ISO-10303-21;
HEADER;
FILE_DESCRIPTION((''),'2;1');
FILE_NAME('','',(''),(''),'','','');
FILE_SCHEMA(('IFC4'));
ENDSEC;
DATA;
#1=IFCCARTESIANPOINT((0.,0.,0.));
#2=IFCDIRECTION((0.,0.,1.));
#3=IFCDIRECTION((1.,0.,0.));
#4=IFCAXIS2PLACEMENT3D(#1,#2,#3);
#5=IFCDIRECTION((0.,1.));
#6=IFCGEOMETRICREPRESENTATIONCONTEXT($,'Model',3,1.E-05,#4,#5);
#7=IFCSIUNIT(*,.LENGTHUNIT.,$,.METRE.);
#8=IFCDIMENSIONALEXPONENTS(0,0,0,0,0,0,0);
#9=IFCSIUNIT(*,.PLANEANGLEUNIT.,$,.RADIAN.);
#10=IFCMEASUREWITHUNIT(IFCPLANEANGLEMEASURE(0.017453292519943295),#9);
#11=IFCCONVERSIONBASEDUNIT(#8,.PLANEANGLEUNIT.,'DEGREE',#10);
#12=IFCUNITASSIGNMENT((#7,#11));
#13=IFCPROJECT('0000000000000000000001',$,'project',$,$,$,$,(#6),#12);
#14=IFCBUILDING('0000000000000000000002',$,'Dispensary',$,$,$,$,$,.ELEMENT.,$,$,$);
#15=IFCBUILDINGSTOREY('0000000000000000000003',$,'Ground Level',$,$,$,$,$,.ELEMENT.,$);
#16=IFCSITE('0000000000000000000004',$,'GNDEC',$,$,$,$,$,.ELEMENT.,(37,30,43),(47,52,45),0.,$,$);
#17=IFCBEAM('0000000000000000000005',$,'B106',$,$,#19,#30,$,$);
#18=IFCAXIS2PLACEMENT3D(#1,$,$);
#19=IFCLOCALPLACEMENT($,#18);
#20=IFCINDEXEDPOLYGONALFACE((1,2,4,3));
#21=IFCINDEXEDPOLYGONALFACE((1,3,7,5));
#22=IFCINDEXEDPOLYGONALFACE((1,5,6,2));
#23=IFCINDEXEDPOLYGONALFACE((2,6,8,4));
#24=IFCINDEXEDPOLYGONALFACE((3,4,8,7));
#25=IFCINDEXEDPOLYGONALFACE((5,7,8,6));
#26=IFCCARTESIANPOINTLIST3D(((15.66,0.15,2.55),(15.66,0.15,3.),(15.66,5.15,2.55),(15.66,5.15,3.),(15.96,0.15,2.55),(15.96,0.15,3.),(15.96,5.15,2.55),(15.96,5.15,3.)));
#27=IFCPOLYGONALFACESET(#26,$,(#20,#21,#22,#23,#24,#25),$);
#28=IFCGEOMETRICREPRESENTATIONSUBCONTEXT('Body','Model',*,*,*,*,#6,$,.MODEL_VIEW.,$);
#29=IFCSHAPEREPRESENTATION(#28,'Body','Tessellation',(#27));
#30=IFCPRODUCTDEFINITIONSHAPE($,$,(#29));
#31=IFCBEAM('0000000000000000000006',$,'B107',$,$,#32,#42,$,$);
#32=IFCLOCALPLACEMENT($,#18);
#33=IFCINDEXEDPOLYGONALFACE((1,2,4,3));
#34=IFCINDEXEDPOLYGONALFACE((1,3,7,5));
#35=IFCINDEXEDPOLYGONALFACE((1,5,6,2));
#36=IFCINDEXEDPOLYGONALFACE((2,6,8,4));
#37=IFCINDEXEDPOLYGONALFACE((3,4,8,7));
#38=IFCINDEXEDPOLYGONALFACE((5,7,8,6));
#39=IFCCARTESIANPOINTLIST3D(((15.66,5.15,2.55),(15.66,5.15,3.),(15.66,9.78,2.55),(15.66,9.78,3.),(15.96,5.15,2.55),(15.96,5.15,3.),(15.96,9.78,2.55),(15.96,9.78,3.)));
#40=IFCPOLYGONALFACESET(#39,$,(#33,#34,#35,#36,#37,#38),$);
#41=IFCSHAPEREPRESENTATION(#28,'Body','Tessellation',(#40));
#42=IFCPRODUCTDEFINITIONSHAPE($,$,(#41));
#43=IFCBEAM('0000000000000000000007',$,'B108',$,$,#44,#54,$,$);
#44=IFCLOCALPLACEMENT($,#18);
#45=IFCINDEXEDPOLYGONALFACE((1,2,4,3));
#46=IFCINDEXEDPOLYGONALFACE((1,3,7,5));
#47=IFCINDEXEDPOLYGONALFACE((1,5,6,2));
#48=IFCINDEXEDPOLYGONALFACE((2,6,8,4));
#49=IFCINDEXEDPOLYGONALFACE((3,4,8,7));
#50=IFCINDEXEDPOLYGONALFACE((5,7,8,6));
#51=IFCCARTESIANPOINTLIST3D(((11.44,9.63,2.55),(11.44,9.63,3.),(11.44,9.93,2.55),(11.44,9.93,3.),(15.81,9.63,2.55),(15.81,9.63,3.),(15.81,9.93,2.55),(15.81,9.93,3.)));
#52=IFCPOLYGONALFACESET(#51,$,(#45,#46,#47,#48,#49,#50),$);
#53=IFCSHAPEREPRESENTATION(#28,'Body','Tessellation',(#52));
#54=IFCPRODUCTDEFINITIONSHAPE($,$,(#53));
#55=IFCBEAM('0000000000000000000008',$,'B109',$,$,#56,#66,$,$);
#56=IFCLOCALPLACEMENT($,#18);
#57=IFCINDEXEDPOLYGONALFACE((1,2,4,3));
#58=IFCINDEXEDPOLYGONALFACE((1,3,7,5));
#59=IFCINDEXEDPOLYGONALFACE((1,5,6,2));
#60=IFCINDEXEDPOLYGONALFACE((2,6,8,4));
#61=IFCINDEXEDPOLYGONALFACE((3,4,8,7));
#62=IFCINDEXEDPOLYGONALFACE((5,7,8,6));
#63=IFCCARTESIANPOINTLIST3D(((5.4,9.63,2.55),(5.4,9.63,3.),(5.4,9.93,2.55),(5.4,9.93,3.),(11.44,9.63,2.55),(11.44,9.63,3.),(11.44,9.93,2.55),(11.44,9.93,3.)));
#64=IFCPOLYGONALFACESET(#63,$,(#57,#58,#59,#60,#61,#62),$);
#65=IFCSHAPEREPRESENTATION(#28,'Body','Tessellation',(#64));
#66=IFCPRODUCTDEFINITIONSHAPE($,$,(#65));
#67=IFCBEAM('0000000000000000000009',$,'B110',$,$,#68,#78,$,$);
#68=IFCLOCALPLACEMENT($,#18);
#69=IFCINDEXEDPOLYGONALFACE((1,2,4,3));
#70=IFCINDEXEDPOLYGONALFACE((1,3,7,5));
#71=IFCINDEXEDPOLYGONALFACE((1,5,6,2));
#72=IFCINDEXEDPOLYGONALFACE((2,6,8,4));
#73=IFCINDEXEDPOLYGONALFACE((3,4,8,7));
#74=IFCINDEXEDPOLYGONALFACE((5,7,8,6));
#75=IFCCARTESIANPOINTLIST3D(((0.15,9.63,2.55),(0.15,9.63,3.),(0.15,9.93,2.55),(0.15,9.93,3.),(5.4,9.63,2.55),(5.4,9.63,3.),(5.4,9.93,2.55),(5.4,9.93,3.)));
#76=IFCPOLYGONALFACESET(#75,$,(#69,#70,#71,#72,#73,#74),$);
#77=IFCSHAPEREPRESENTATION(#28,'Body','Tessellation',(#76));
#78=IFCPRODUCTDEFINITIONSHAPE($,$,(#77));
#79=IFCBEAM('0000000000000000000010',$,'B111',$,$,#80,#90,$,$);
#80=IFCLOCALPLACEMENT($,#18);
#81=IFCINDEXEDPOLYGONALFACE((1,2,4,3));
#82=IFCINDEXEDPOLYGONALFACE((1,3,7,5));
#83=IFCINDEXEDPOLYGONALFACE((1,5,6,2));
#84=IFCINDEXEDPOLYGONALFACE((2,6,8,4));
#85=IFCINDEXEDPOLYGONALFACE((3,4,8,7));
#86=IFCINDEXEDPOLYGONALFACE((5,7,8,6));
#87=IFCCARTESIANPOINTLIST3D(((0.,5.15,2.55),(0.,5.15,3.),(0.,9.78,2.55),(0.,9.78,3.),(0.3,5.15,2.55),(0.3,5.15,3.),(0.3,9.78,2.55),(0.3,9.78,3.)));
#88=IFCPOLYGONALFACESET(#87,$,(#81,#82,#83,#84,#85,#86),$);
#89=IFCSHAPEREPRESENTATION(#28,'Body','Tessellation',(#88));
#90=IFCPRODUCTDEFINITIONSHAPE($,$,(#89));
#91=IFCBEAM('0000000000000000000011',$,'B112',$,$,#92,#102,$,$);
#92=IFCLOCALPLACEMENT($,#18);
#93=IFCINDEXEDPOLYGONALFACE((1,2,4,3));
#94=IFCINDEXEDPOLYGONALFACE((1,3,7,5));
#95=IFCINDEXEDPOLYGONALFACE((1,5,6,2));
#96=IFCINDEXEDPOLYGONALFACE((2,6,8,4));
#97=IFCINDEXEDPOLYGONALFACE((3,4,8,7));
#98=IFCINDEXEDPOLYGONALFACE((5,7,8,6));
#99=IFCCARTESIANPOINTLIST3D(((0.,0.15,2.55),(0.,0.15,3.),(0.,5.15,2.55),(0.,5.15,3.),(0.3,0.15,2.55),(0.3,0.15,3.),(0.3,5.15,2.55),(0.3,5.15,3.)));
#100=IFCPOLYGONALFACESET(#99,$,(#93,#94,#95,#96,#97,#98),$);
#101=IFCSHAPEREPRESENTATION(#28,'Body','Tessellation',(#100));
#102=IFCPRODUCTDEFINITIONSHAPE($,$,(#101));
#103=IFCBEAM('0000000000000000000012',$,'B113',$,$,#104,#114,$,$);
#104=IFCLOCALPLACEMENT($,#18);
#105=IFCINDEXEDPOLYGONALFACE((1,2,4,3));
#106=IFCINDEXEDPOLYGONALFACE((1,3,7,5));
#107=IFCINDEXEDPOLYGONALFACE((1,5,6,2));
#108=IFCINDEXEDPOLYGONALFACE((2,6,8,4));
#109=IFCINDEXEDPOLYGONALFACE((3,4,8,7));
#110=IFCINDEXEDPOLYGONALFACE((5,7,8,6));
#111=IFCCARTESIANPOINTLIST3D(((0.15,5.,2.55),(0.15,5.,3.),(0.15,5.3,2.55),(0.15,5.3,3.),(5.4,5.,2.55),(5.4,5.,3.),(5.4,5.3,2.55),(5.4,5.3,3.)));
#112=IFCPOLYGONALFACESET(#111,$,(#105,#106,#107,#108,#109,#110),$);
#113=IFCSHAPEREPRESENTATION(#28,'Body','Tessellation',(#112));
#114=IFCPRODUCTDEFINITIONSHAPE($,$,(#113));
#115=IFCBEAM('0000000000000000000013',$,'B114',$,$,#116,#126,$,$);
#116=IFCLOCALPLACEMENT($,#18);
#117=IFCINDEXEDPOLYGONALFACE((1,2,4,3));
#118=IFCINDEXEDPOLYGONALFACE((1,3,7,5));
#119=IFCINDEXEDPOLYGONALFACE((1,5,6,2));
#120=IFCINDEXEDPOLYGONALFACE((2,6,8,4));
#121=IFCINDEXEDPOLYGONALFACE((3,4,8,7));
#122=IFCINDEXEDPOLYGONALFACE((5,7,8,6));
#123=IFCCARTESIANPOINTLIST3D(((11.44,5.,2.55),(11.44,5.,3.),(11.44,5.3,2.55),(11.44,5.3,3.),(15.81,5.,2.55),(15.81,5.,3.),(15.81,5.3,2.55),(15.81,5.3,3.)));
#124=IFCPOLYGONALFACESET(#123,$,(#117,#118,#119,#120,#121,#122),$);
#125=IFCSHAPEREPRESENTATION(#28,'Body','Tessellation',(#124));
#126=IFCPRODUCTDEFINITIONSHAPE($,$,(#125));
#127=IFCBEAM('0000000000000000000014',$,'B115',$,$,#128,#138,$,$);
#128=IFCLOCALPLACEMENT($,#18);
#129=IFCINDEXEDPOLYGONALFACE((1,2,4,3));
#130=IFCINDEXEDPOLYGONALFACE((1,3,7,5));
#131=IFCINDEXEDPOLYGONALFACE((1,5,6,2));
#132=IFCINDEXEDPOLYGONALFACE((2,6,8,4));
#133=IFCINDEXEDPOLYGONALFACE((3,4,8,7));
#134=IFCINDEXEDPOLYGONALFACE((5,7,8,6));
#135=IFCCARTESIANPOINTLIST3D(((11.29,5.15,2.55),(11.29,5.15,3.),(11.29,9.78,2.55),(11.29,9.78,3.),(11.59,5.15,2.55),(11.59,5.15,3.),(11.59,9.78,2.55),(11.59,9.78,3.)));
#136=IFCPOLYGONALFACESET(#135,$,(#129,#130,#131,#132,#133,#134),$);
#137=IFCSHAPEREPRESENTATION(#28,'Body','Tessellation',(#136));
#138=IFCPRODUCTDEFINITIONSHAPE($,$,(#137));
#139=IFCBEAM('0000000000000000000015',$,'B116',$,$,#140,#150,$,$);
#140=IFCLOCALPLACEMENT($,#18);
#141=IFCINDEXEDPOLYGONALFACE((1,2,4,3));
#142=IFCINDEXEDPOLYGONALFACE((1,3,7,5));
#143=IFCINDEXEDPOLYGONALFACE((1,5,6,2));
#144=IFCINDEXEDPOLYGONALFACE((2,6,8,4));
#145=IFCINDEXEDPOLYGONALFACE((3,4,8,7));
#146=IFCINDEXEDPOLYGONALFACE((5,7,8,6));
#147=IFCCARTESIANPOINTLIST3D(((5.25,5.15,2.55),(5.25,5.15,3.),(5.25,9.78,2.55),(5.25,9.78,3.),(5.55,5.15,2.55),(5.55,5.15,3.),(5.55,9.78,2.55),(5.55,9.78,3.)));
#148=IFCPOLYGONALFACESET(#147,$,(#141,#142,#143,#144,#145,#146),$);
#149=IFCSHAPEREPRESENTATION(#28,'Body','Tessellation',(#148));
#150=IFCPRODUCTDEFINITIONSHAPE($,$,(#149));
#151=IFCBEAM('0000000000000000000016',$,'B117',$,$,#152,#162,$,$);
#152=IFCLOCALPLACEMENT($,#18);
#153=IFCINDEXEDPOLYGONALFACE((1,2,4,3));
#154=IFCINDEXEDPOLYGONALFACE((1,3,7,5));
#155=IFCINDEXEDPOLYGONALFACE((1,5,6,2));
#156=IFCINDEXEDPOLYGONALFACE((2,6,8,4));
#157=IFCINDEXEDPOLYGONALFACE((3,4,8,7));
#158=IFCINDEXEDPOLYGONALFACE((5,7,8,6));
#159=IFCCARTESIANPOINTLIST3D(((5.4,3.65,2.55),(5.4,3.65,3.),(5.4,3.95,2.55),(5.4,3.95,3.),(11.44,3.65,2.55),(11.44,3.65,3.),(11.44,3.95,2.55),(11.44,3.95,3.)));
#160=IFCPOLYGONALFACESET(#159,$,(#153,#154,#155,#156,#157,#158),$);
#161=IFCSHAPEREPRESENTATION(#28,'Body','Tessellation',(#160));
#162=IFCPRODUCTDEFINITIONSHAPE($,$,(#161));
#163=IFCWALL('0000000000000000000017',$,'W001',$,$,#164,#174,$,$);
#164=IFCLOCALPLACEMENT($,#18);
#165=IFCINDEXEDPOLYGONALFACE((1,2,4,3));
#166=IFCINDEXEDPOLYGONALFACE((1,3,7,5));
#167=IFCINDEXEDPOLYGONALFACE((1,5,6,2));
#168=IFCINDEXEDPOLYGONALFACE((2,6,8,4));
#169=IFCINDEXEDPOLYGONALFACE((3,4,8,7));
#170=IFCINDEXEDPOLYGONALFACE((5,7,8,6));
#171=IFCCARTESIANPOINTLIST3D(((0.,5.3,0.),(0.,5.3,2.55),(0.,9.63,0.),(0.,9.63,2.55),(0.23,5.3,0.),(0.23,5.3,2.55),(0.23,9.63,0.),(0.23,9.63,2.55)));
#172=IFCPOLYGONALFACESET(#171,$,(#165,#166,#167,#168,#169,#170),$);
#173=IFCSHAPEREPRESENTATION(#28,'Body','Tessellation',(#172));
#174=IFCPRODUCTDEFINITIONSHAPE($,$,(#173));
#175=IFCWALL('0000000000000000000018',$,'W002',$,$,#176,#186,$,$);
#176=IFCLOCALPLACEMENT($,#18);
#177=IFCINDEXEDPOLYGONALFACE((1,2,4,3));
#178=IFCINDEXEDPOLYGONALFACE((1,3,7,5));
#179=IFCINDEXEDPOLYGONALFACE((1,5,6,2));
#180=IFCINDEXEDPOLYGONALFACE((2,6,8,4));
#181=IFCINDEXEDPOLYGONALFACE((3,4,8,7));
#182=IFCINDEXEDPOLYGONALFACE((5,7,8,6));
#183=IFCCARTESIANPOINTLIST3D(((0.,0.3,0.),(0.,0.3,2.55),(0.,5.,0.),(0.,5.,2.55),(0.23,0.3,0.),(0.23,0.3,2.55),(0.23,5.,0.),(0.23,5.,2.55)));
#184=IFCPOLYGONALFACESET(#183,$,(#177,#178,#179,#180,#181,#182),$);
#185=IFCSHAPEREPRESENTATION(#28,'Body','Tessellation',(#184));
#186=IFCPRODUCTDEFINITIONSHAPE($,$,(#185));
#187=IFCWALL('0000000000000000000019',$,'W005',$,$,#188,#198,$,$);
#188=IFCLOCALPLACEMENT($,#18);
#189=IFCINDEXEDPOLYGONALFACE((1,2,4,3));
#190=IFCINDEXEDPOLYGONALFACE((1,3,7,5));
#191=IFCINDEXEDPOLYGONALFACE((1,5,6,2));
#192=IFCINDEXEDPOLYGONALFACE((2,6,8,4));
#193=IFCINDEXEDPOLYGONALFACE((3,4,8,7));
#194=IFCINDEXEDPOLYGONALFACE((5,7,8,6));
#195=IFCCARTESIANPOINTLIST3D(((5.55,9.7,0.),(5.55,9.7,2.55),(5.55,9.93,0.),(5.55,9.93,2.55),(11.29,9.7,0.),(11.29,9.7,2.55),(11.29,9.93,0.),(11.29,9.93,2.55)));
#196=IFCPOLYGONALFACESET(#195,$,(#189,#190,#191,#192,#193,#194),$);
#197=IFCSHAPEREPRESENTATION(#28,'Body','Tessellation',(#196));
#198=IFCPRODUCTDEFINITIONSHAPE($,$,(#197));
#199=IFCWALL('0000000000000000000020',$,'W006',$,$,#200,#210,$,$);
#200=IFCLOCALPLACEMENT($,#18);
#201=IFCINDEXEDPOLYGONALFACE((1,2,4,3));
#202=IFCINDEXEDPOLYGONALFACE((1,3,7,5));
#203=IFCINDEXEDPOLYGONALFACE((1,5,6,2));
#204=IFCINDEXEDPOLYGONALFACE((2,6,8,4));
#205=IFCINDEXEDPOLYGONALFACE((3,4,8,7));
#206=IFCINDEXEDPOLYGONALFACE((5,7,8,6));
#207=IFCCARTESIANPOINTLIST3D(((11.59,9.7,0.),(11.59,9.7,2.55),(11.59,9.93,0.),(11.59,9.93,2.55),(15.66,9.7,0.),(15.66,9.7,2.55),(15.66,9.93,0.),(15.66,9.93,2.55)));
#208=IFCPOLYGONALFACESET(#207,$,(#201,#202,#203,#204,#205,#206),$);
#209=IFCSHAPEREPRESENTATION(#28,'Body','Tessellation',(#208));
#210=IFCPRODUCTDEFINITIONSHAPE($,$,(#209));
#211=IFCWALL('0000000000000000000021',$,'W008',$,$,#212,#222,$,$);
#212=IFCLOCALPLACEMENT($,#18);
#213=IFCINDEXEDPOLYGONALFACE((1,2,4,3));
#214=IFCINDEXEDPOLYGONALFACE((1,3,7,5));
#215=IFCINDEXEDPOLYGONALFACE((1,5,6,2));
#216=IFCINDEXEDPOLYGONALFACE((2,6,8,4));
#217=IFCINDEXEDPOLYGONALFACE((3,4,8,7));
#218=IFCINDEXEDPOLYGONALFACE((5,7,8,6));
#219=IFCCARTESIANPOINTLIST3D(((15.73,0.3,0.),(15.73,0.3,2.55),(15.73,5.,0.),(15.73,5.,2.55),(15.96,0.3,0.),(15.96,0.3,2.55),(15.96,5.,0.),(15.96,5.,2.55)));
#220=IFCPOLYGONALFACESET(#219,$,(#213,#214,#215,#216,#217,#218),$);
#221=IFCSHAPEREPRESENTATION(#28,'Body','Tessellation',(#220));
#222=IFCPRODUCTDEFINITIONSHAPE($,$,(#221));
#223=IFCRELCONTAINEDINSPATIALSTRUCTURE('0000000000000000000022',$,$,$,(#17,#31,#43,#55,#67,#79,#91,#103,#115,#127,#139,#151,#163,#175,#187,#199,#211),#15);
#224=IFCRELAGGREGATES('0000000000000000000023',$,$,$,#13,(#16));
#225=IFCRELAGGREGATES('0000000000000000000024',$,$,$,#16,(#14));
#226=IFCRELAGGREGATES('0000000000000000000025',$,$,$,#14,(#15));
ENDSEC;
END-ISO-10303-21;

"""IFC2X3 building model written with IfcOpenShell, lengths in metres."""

from ifc_helpers import new_model, entity, si_unit, converted_unit, direction, frame, frame_2d, origin_with_axes, place, context, subcontext, project, spatial, rectangle, extrude, element, save


model = new_model("IFC2X3")

# Units and contexts
model_context = context("Model", 3, precision=1e-05, world=origin_with_axes(), true_north=direction((0.0, 1.0)))
body_context = subcontext(model_context, "Body", "Model", "MODEL_VIEW")
ifc_project = project(units=[si_unit("LENGTHUNIT", "METRE"), converted_unit("PLANEANGLEUNIT", "DEGREE", entity("IfcPlaneAngleMeasure", 0.017453292519943295), si_unit("PLANEANGLEUNIT", "RADIAN"), dimensions=[0, 0, 0, 0, 0, 0, 0])], contexts=[model_context])

# Site, building, storey
site = spatial("IfcSite", under=ifc_project, Name="GNDEC", CompositionType="ELEMENT", RefLatitude=(37, 30, 43), RefLongitude=(47, 52, 45), RefElevation=0.0)
building = spatial("IfcBuilding", under=site, Name="Dispensary", CompositionType="ELEMENT")
storey = spatial("IfcBuildingStorey", under=building, Name="Ground Level", CompositionType="ELEMENT")

# Shared definitions
placement = place(None, origin_with_axes())

# Beams
element("IfcBeam", 1, at=placement, inside=storey, Name="B106", context=body_context, shape_type="SweptSolid", body=[
    extrude(rectangle(XDim=0.3, YDim=0.45, at=frame_2d((0.0, 0.0), x_axis=(0.0, 1.0))), frame((15.81, 0.15, 2.775), z_axis=(0.0, 1.0, 0.0), x_axis=(0.0, 0.0, -1.0)), (0.0, 0.0, 1.0), 5.0),
])
element("IfcBeam", 2, at=placement, inside=storey, Name="B107", context=body_context, shape_type="SweptSolid", body=[
    extrude(rectangle(XDim=0.3, YDim=0.45, at=frame_2d((0.0, 0.0), x_axis=(0.0, 1.0))), frame((15.81, 5.15, 2.775), z_axis=(0.0, 1.0, 0.0), x_axis=(0.0, 0.0, -1.0)), (0.0, 0.0, 1.0), 4.63),
])
element("IfcBeam", 3, at=placement, inside=storey, Name="B108", context=body_context, shape_type="SweptSolid", body=[
    extrude(rectangle(XDim=0.3, YDim=0.45, at=frame_2d((0.0, 0.0), x_axis=(0.0, 1.0))), frame((15.81, 9.78, 2.775), z_axis=(-1.0, 0.0, 0.0), x_axis=(0.0, 0.0, -1.0)), (0.0, 0.0, 1.0), 4.37),
])
element("IfcBeam", 4, at=placement, inside=storey, Name="B109", context=body_context, shape_type="SweptSolid", body=[
    extrude(rectangle(XDim=0.3, YDim=0.45, at=frame_2d((0.0, 0.0), x_axis=(0.0, 1.0))), frame((11.44, 9.78, 2.775), z_axis=(-1.0, 0.0, 0.0), x_axis=(0.0, 0.0, -1.0)), (0.0, 0.0, 1.0), 6.04),
])
element("IfcBeam", 5, at=placement, inside=storey, Name="B110", context=body_context, shape_type="SweptSolid", body=[
    extrude(rectangle(XDim=0.3, YDim=0.45, at=frame_2d((0.0, 0.0), x_axis=(0.0, 1.0))), frame((5.4, 9.78, 2.775), z_axis=(-1.0, 0.0, 0.0), x_axis=(0.0, 0.0, -1.0)), (0.0, 0.0, 1.0), 5.25),
])
element("IfcBeam", 6, at=placement, inside=storey, Name="B111", context=body_context, shape_type="SweptSolid", body=[
    extrude(rectangle(XDim=0.3, YDim=0.45, at=frame_2d((0.0, 0.0), x_axis=(0.0, 1.0))), frame((0.15, 9.78, 2.775), z_axis=(0.0, -1.0, 0.0), x_axis=(0.0, 0.0, -1.0)), (0.0, 0.0, 1.0), 4.63),
])
element("IfcBeam", 7, at=placement, inside=storey, Name="B112", context=body_context, shape_type="SweptSolid", body=[
    extrude(rectangle(XDim=0.3, YDim=0.45, at=frame_2d((0.0, 0.0), x_axis=(0.0, 1.0))), frame((0.15, 5.15, 2.775), z_axis=(0.0, -1.0, 0.0), x_axis=(0.0, 0.0, -1.0)), (0.0, 0.0, 1.0), 5.0),
])
element("IfcBeam", 8, at=placement, inside=storey, Name="B113", context=body_context, shape_type="SweptSolid", body=[
    extrude(rectangle(XDim=0.3, YDim=0.45, at=frame_2d((0.0, 0.0), x_axis=(0.0, 1.0))), frame((0.15, 5.15, 2.775), z_axis=(1.0, 0.0, 0.0), x_axis=(0.0, 0.0, -1.0)), (0.0, 0.0, 1.0), 5.25),
])
element("IfcBeam", 9, at=placement, inside=storey, Name="B114", context=body_context, shape_type="SweptSolid", body=[
    extrude(rectangle(XDim=0.3, YDim=0.45, at=frame_2d((0.0, 0.0), x_axis=(0.0, 1.0))), frame((15.81, 5.15, 2.775), z_axis=(-1.0, 0.0, 0.0), x_axis=(0.0, 0.0, -1.0)), (0.0, 0.0, 1.0), 4.37),
])
element("IfcBeam", 10, at=placement, inside=storey, Name="B115", context=body_context, shape_type="SweptSolid", body=[
    extrude(rectangle(XDim=0.3, YDim=0.45, at=frame_2d((0.0, 0.0), x_axis=(0.0, 1.0))), frame((11.44, 5.15, 2.775), z_axis=(0.0, 1.0, 0.0), x_axis=(0.0, 0.0, -1.0)), (0.0, 0.0, 1.0), 4.63),
])
element("IfcBeam", 11, at=placement, inside=storey, Name="B116", context=body_context, shape_type="SweptSolid", body=[
    extrude(rectangle(XDim=0.3, YDim=0.45, at=frame_2d((0.0, 0.0), x_axis=(0.0, 1.0))), frame((5.4, 5.15, 2.775), z_axis=(0.0, 1.0, 0.0), x_axis=(0.0, 0.0, -1.0)), (0.0, 0.0, 1.0), 4.63),
])
element("IfcBeam", 12, at=placement, inside=storey, Name="B117", context=body_context, shape_type="SweptSolid", body=[
    extrude(rectangle(XDim=0.3, YDim=0.45, at=frame_2d((0.0, 0.0), x_axis=(0.0, 1.0))), frame((5.4, 3.8, 2.775), z_axis=(1.0, 0.0, 0.0), x_axis=(0.0, 0.0, -1.0)), (0.0, 0.0, 1.0), 6.04),
])

# Walls
element("IfcWall", 13, at=placement, inside=storey, Name="W001", context=body_context, shape_type="SweptSolid", body=[
    extrude(rectangle(XDim=4.33, YDim=0.23, at=frame_2d((0.0, 0.0), x_axis=(0.0, -1.0))), frame((0.115, 7.465, 0.0), z_axis=(0.0, 0.0, 1.0), x_axis=(1.0, 0.0, 0.0)), (0.0, 0.0, 1.0), 2.55),
])
element("IfcWall", 14, at=placement, inside=storey, Name="W002", context=body_context, shape_type="SweptSolid", body=[
    extrude(rectangle(XDim=4.7, YDim=0.23, at=frame_2d((0.0, 0.0), x_axis=(0.0, -1.0))), frame((0.115, 2.65, 0.0), z_axis=(0.0, 0.0, 1.0), x_axis=(1.0, 0.0, 0.0)), (0.0, 0.0, 1.0), 2.55),
])
element("IfcWall", 15, at=placement, inside=storey, Name="W005", context=body_context, shape_type="SweptSolid", body=[
    extrude(rectangle(XDim=5.74, YDim=0.23, at=frame_2d((0.0, 0.0), x_axis=(-1.0, 0.0))), frame((8.42, 9.815, 0.0), z_axis=(0.0, 0.0, 1.0), x_axis=(1.0, 0.0, 0.0)), (0.0, 0.0, 1.0), 2.55),
])
element("IfcWall", 16, at=placement, inside=storey, Name="W006", context=body_context, shape_type="SweptSolid", body=[
    extrude(rectangle(XDim=4.07, YDim=0.23, at=frame_2d((0.0, 0.0), x_axis=(-1.0, 0.0))), frame((13.625, 9.815, 0.0), z_axis=(0.0, 0.0, 1.0), x_axis=(1.0, 0.0, 0.0)), (0.0, 0.0, 1.0), 2.55),
])
element("IfcWall", 17, at=placement, inside=storey, Name="W008", context=body_context, shape_type="SweptSolid", body=[
    extrude(rectangle(XDim=4.7, YDim=0.23, at=frame_2d((0.0, 0.0), x_axis=(0.0, 1.0))), frame((15.845, 2.65, 0.0), z_axis=(0.0, 0.0, 1.0), x_axis=(1.0, 0.0, 0.0)), (0.0, 0.0, 1.0), 2.55),
])

save(model, "model.ifc")
